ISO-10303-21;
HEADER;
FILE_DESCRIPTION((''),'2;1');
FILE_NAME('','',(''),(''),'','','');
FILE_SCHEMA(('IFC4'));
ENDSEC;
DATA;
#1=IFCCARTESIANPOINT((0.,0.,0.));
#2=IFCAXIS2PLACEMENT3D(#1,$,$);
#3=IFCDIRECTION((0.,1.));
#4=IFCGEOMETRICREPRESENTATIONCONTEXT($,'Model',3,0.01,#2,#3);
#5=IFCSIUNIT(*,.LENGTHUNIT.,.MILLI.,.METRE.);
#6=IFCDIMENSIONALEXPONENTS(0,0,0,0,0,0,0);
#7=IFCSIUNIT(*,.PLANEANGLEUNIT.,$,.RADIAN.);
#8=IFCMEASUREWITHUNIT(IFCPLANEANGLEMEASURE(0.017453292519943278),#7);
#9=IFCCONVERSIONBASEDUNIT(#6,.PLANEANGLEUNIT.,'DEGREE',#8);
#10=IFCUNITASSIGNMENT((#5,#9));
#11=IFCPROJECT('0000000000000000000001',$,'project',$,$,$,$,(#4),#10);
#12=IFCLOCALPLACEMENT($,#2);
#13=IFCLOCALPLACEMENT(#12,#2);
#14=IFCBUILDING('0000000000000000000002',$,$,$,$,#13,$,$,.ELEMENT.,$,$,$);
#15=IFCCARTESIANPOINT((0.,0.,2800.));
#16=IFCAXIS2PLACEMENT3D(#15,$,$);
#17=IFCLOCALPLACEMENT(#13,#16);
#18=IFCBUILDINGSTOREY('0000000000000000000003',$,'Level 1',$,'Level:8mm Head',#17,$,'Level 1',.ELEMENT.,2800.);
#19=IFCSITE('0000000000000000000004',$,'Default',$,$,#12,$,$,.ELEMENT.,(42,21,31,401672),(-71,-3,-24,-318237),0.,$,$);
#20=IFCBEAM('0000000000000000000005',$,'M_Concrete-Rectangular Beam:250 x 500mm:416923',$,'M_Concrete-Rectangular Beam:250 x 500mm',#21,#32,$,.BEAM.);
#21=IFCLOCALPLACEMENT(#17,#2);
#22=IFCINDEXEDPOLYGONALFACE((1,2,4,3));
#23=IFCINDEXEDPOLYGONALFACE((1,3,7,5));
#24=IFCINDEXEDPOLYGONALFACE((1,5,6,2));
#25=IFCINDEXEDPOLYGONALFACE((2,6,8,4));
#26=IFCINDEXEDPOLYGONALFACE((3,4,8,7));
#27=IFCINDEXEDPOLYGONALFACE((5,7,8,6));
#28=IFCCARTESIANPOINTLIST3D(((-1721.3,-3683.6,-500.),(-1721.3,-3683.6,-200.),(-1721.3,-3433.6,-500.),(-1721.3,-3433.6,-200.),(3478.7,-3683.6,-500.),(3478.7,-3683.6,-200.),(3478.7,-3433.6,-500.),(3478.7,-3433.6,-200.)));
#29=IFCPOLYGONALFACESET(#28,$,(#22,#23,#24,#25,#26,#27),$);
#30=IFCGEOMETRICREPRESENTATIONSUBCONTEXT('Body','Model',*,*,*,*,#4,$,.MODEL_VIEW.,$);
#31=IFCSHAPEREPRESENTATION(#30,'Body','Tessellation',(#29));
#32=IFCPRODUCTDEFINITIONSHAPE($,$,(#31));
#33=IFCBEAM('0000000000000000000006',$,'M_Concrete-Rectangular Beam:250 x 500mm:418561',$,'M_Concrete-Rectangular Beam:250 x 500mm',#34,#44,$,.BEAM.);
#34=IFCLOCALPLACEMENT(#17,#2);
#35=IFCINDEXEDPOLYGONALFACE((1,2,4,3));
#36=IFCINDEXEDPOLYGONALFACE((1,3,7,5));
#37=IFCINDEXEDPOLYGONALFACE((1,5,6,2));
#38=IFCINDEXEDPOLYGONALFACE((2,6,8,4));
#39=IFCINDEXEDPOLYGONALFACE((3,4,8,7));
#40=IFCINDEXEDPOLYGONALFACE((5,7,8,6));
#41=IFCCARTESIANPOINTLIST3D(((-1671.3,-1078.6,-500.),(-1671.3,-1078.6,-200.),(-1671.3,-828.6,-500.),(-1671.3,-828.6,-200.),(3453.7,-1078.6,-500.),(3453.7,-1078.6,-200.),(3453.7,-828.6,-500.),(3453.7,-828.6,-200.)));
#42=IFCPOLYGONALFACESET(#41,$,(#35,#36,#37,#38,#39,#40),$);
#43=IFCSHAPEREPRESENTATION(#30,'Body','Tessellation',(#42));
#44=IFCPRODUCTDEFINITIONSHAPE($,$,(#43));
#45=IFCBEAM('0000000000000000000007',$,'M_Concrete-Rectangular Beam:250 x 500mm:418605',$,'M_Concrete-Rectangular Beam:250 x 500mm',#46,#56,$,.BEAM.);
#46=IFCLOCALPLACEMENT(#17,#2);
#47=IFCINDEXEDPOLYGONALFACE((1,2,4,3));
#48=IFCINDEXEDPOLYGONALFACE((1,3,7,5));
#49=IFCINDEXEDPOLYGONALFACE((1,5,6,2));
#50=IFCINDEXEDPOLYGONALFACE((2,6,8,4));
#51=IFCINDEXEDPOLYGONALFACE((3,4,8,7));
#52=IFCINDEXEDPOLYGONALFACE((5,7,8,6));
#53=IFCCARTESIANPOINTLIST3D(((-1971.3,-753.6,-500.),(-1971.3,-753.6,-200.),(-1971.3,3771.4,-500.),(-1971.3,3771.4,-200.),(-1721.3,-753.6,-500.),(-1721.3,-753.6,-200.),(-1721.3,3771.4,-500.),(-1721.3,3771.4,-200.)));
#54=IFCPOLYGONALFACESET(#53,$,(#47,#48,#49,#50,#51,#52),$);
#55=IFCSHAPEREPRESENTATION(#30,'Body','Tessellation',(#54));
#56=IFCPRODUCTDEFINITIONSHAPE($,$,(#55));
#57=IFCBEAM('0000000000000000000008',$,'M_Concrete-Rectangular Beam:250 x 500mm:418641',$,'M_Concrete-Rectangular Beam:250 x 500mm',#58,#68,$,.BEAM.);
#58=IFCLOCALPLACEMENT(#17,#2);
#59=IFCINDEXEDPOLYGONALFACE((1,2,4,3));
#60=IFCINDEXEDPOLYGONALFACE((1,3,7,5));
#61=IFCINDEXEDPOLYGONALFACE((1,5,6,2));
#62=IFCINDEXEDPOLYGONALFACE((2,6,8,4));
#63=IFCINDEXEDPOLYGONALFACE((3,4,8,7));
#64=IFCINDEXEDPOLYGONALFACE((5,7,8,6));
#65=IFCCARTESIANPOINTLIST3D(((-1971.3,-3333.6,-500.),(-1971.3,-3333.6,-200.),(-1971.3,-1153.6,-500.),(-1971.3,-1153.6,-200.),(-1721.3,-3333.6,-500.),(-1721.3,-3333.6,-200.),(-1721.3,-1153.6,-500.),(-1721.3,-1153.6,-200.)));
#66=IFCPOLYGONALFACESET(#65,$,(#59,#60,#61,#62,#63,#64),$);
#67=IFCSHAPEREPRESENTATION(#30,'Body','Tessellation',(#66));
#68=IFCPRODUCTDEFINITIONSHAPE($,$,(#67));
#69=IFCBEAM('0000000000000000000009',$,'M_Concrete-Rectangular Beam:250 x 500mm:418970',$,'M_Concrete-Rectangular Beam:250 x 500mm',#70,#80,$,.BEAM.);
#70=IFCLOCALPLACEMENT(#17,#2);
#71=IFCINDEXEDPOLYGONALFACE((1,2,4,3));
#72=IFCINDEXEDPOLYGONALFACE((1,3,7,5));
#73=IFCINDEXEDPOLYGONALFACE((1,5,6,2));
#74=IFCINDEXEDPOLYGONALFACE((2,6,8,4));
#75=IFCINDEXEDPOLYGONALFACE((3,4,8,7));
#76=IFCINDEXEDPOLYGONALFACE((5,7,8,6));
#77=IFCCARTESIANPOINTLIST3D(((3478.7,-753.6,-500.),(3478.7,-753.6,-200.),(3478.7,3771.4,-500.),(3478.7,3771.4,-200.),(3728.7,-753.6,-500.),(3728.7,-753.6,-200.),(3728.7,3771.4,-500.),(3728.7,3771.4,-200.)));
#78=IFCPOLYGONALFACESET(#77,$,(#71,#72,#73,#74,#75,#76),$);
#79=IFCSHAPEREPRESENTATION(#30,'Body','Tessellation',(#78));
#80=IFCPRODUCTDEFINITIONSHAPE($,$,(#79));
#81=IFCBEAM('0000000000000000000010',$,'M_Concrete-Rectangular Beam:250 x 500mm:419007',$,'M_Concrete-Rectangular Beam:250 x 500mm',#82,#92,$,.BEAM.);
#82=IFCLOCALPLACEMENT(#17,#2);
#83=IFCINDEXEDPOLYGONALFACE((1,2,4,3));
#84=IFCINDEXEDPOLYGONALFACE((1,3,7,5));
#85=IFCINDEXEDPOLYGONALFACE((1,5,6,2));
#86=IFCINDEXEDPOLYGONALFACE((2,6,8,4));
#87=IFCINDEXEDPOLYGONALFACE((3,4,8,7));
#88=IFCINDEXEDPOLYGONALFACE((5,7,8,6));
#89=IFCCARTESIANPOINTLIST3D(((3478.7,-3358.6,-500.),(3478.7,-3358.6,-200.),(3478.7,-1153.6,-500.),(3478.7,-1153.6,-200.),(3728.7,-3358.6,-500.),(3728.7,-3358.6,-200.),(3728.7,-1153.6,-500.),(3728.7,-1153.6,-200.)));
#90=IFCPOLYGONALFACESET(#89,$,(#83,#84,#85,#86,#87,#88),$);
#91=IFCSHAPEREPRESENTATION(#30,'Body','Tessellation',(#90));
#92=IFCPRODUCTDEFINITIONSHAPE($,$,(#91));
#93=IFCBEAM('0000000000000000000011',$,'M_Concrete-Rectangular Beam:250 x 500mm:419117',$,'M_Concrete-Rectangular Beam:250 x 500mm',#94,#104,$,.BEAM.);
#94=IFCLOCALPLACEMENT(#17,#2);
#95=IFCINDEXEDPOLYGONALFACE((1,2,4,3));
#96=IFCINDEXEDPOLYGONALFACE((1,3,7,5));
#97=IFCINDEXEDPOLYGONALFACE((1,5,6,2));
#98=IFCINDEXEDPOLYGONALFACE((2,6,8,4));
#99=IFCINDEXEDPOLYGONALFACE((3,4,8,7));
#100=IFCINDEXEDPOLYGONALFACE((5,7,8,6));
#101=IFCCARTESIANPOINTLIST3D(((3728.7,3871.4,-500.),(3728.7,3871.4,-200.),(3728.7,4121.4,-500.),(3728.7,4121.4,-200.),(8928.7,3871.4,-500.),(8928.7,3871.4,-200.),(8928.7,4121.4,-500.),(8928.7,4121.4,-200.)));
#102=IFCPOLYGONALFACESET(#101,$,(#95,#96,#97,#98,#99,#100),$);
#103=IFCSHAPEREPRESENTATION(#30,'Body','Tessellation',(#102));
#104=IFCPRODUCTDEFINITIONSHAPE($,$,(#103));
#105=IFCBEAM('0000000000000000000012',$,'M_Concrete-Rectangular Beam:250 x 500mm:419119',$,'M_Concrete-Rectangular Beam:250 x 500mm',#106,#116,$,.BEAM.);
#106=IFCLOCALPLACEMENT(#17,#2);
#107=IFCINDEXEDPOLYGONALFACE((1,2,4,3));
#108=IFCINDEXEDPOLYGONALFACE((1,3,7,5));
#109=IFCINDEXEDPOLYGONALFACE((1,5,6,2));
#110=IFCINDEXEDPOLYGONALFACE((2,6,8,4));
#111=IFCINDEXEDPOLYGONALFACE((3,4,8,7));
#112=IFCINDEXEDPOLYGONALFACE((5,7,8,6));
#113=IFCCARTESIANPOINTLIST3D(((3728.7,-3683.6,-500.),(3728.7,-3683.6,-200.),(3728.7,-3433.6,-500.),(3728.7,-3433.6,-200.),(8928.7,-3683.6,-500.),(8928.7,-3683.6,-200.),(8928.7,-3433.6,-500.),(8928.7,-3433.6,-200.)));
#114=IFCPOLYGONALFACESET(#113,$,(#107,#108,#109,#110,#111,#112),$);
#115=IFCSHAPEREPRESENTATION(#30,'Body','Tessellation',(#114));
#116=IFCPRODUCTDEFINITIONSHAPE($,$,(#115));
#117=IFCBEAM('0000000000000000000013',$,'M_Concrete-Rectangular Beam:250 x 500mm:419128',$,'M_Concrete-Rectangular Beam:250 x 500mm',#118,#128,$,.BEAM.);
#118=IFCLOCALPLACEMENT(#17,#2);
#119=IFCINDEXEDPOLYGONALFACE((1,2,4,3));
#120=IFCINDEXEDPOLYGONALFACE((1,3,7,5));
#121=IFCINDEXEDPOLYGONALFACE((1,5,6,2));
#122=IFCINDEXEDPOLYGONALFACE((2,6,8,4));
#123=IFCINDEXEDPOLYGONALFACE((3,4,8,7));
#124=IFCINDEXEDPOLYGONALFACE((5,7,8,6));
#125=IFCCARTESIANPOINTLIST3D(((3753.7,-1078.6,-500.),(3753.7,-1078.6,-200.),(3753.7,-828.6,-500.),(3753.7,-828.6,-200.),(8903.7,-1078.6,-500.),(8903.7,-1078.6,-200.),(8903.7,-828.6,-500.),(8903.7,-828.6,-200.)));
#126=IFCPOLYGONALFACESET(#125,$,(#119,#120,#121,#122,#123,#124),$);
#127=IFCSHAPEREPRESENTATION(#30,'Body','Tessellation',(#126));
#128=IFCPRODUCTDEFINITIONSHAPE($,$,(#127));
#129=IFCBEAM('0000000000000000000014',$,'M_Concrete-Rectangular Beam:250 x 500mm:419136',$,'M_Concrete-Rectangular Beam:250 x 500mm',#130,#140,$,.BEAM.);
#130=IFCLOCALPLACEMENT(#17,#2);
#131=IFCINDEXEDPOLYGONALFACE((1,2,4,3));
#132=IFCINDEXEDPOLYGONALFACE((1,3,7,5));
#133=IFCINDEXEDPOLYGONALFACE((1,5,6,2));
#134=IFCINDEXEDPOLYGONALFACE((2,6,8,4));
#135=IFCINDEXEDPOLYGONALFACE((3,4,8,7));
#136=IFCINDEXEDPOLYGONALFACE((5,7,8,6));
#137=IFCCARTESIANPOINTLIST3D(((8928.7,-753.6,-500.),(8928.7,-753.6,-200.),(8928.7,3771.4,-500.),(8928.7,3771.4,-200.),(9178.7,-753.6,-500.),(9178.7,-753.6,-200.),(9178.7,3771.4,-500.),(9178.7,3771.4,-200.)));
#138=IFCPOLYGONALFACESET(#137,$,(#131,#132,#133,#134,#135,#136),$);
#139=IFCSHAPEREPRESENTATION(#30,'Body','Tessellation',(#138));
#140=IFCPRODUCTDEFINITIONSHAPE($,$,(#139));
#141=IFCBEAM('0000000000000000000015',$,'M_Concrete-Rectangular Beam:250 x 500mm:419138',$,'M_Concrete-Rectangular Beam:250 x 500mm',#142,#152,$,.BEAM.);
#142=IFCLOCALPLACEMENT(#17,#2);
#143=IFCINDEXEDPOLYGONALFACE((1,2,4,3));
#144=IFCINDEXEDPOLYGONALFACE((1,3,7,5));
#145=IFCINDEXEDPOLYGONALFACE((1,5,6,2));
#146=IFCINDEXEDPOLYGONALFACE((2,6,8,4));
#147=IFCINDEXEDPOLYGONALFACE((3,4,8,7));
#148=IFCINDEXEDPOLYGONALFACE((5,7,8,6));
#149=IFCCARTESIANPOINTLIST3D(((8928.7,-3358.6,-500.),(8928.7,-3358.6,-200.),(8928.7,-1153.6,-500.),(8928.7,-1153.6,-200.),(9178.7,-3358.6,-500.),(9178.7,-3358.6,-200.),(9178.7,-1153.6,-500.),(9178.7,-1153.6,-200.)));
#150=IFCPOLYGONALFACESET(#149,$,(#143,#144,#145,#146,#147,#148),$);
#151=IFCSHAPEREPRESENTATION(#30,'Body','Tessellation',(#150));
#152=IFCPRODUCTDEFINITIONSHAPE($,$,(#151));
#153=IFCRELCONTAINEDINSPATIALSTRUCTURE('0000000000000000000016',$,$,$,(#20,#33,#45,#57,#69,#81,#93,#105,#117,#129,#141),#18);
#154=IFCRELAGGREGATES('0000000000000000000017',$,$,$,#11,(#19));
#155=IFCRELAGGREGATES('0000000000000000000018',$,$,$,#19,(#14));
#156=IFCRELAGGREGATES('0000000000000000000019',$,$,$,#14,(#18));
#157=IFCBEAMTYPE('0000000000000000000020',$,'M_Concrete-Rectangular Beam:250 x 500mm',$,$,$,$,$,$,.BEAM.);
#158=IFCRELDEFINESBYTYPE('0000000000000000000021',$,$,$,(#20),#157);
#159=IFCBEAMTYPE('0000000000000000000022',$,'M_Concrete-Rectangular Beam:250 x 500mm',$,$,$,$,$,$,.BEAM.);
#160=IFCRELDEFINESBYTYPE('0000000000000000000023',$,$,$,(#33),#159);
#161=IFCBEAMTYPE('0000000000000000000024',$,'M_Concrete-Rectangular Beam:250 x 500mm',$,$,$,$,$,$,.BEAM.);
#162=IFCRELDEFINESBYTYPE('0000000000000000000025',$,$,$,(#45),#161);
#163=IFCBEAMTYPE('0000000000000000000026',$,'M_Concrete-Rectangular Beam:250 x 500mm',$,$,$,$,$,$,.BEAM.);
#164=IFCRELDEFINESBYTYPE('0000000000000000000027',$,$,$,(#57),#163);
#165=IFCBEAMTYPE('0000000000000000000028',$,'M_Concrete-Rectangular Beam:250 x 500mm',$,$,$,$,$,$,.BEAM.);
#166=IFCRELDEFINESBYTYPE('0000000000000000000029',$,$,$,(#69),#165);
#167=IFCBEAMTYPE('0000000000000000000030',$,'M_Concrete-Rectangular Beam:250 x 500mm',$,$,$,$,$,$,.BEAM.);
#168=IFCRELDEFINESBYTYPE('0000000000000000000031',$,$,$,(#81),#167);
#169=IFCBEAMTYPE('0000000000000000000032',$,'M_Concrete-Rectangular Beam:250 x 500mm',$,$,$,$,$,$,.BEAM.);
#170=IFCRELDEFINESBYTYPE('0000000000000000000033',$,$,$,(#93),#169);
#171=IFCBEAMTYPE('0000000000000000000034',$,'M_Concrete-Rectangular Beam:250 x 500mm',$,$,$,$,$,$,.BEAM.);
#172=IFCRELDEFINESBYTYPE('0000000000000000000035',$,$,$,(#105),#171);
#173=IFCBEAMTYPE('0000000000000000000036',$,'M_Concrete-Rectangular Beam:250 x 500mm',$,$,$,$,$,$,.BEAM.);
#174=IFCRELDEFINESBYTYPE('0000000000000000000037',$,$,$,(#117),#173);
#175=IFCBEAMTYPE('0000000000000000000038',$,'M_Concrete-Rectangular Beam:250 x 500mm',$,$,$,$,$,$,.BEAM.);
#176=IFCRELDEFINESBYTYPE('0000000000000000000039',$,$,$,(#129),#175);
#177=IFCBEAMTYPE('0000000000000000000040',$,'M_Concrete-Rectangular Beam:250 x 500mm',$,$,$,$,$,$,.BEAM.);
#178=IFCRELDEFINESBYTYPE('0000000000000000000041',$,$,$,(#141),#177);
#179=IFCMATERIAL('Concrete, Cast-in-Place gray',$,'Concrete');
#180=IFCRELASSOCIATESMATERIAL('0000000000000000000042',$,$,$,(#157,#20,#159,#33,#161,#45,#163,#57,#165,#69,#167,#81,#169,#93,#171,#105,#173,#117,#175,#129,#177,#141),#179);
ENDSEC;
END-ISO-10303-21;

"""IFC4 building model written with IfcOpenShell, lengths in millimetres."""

from ifc_helpers import new_model, entity, si_unit, converted_unit, direction, frame, origin, place, context, subcontext, project, spatial, indexed_curve, outline, extrude, source, transform, mapped, material, type_object, type_shapes, element, save


model = new_model("IFC4")

# Units and contexts
model_context = context("Model", 3, precision=0.01, world=origin(), true_north=direction((0.0, 1.0)))
body_context = subcontext(model_context, "Body", "Model", "MODEL_VIEW")
ifc_project = project(units=[si_unit("LENGTHUNIT", "METRE", prefix="MILLI"), converted_unit("PLANEANGLEUNIT", "DEGREE", entity("IfcPlaneAngleMeasure", 0.017453292519943278), si_unit("PLANEANGLEUNIT", "RADIAN"), dimensions=[0, 0, 0, 0, 0, 0, 0])], contexts=[model_context])

# Site, building, storey
site_placement = place(None, origin())
site = spatial("IfcSite", under=ifc_project, at=site_placement, Name="Default", CompositionType="ELEMENT", RefLatitude=(42, 21, 31, 401672), RefLongitude=(-71, -3, -24, -318237), RefElevation=0.0)
building_placement = place(site_placement, origin())
building = spatial("IfcBuilding", under=site, at=building_placement, CompositionType="ELEMENT")
storey_placement = place(building_placement, frame((0.0, 0.0, 2800.0)))
storey = spatial("IfcBuildingStorey", under=building, at=storey_placement, Name="Level 1", ObjectType="Level:8mm Head", LongName="Level 1", CompositionType="ELEMENT", Elevation=2800.0)

# Shared definitions
ifc_material_1 = material(Name="Concrete, Cast-in-Place gray", Category="Concrete")

# Beams
beam_type_1 = type_object("IfcBeamType", Name="M_Concrete-Rectangular Beam:250 x 500mm", PredefinedType="BEAM", material=ifc_material_1)
shared_shape_1 = source(origin(), body_context, "Body", "SweptSolid", [
    extrude(outline(indexed_curve([(-150.0, -125.0), (150.0, -125.0), (150.0, 125.0), (-150.0, 125.0), (-150.0, -125.0)], self_intersect=False)), frame((-1721.3, -3558.6, 2450.0), z_axis=(1.0, 0.0, 0.0), x_axis=(0.0, 0.0, -1.0)), (0.0, 0.0, 1.0), 5200.0),
])
type_shapes(beam_type_1, [shared_shape_1])
beam_1_placement = place(storey_placement, frame((0.0, 0.0, -2800.0)))
element("IfcBeam", 1, at=beam_1_placement, inside=storey, type_object=beam_type_1, material=ifc_material_1, Name="M_Concrete-Rectangular Beam:250 x 500mm:416923", ObjectType="M_Concrete-Rectangular Beam:250 x 500mm", PredefinedType="BEAM", context=body_context, shape_type="MappedRepresentation", body=[
    mapped(shared_shape_1, transform((0.0, 0.0, 0.0), scale=1.0)),
])
beam_type_2 = type_object("IfcBeamType", Name="M_Concrete-Rectangular Beam:250 x 500mm", PredefinedType="BEAM", material=ifc_material_1)
shared_shape_2 = source(origin(), body_context, "Body", "SweptSolid", [
    extrude(outline(indexed_curve([(-150.0, -125.0), (150.0, -125.0), (150.0, 125.0), (-150.0, 125.0), (-150.0, -125.0)], self_intersect=False)), frame((-1671.3, -953.6, 2450.0), z_axis=(1.0, 0.0, 0.0), x_axis=(0.0, 0.0, -1.0)), (0.0, 0.0, 1.0), 5125.0),
])
type_shapes(beam_type_2, [shared_shape_2])
beam_2_placement = place(storey_placement, frame((0.0, 0.0, -2800.0)))
element("IfcBeam", 2, at=beam_2_placement, inside=storey, type_object=beam_type_2, material=ifc_material_1, Name="M_Concrete-Rectangular Beam:250 x 500mm:418561", ObjectType="M_Concrete-Rectangular Beam:250 x 500mm", PredefinedType="BEAM", context=body_context, shape_type="MappedRepresentation", body=[
    mapped(shared_shape_2, transform((0.0, 0.0, 0.0), scale=1.0)),
])
beam_type_3 = type_object("IfcBeamType", Name="M_Concrete-Rectangular Beam:250 x 500mm", PredefinedType="BEAM", material=ifc_material_1)
shared_shape_3 = source(origin(), body_context, "Body", "SweptSolid", [
    extrude(outline(indexed_curve([(-125.0, -150.0), (125.0, -150.0), (125.0, 150.0), (-125.0, 150.0), (-125.0, -150.0)], self_intersect=False)), frame((-1846.3, 3771.4, 2450.0), z_axis=(0.0, -1.0, 0.0), x_axis=(-1.0, 0.0, 0.0)), (0.0, 0.0, 1.0), 4525.0),
])
type_shapes(beam_type_3, [shared_shape_3])
beam_3_placement = place(storey_placement, frame((0.0, 0.0, -2800.0)))
element("IfcBeam", 3, at=beam_3_placement, inside=storey, type_object=beam_type_3, material=ifc_material_1, Name="M_Concrete-Rectangular Beam:250 x 500mm:418605", ObjectType="M_Concrete-Rectangular Beam:250 x 500mm", PredefinedType="BEAM", context=body_context, shape_type="MappedRepresentation", body=[
    mapped(shared_shape_3, transform((0.0, 0.0, 0.0), scale=1.0)),
])
beam_type_4 = type_object("IfcBeamType", Name="M_Concrete-Rectangular Beam:250 x 500mm", PredefinedType="BEAM", material=ifc_material_1)
shared_shape_4 = source(origin(), body_context, "Body", "SweptSolid", [
    extrude(outline(indexed_curve([(-125.0, -150.0), (125.0, -150.0), (125.0, 150.0), (-125.0, 150.0), (-125.0, -150.0)], self_intersect=False)), frame((-1846.3, -1153.6, 2450.0), z_axis=(0.0, -1.0, 0.0), x_axis=(-1.0, 0.0, 0.0)), (0.0, 0.0, 1.0), 2180.0),
])
type_shapes(beam_type_4, [shared_shape_4])
beam_4_placement = place(storey_placement, frame((0.0, 0.0, -2800.0)))
element("IfcBeam", 4, at=beam_4_placement, inside=storey, type_object=beam_type_4, material=ifc_material_1, Name="M_Concrete-Rectangular Beam:250 x 500mm:418641", ObjectType="M_Concrete-Rectangular Beam:250 x 500mm", PredefinedType="BEAM", context=body_context, shape_type="MappedRepresentation", body=[
    mapped(shared_shape_4, transform((0.0, 0.0, 0.0), scale=1.0)),
])
beam_type_5 = type_object("IfcBeamType", Name="M_Concrete-Rectangular Beam:250 x 500mm", PredefinedType="BEAM", material=ifc_material_1)
shared_shape_5 = source(origin(), body_context, "Body", "SweptSolid", [
    extrude(outline(indexed_curve([(-125.0, -150.0), (125.0, -150.0), (125.0, 150.0), (-125.0, 150.0), (-125.0, -150.0)], self_intersect=False)), frame((3603.7, 3771.4, 2450.0), z_axis=(0.0, -1.0, 0.0), x_axis=(-1.0, 0.0, 0.0)), (0.0, 0.0, 1.0), 4525.0),
])
type_shapes(beam_type_5, [shared_shape_5])
beam_5_placement = place(storey_placement, frame((0.0, 0.0, -2800.0)))
element("IfcBeam", 5, at=beam_5_placement, inside=storey, type_object=beam_type_5, material=ifc_material_1, Name="M_Concrete-Rectangular Beam:250 x 500mm:418970", ObjectType="M_Concrete-Rectangular Beam:250 x 500mm", PredefinedType="BEAM", context=body_context, shape_type="MappedRepresentation", body=[
    mapped(shared_shape_5, transform((0.0, 0.0, 0.0), scale=1.0)),
])
beam_type_6 = type_object("IfcBeamType", Name="M_Concrete-Rectangular Beam:250 x 500mm", PredefinedType="BEAM", material=ifc_material_1)
shared_shape_6 = source(origin(), body_context, "Body", "SweptSolid", [
    extrude(outline(indexed_curve([(-125.0, -150.0), (125.0, -150.0), (125.0, 150.0), (-125.0, 150.0), (-125.0, -150.0)], self_intersect=False)), frame((3603.7, -1153.6, 2450.0), z_axis=(0.0, -1.0, 0.0), x_axis=(-1.0, 0.0, 0.0)), (0.0, 0.0, 1.0), 2205.0),
])
type_shapes(beam_type_6, [shared_shape_6])
beam_6_placement = place(storey_placement, frame((0.0, 0.0, -2800.0)))
element("IfcBeam", 6, at=beam_6_placement, inside=storey, type_object=beam_type_6, material=ifc_material_1, Name="M_Concrete-Rectangular Beam:250 x 500mm:419007", ObjectType="M_Concrete-Rectangular Beam:250 x 500mm", PredefinedType="BEAM", context=body_context, shape_type="MappedRepresentation", body=[
    mapped(shared_shape_6, transform((0.0, 0.0, 0.0), scale=1.0)),
])
beam_type_7 = type_object("IfcBeamType", Name="M_Concrete-Rectangular Beam:250 x 500mm", PredefinedType="BEAM", material=ifc_material_1)
shared_shape_7 = source(origin(), body_context, "Body", "SweptSolid", [
    extrude(outline(indexed_curve([(-150.0, -125.0), (150.0, -125.0), (150.0, 125.0), (-150.0, 125.0), (-150.0, -125.0)], self_intersect=False)), frame((3728.7, 3996.4, 2450.0), z_axis=(1.0, 0.0, 0.0), x_axis=(0.0, 0.0, -1.0)), (0.0, 0.0, 1.0), 5200.0),
])
type_shapes(beam_type_7, [shared_shape_7])
beam_7_placement = place(storey_placement, frame((0.0, 0.0, -2800.0)))
element("IfcBeam", 7, at=beam_7_placement, inside=storey, type_object=beam_type_7, material=ifc_material_1, Name="M_Concrete-Rectangular Beam:250 x 500mm:419117", ObjectType="M_Concrete-Rectangular Beam:250 x 500mm", PredefinedType="BEAM", context=body_context, shape_type="MappedRepresentation", body=[
    mapped(shared_shape_7, transform((0.0, 0.0, 0.0), scale=1.0)),
])
beam_type_8 = type_object("IfcBeamType", Name="M_Concrete-Rectangular Beam:250 x 500mm", PredefinedType="BEAM", material=ifc_material_1)
shared_shape_8 = source(origin(), body_context, "Body", "SweptSolid", [
    extrude(outline(indexed_curve([(-150.0, -125.0), (150.0, -125.0), (150.0, 125.0), (-150.0, 125.0), (-150.0, -125.0)], self_intersect=False)), frame((3728.7, -3558.6, 2450.0), z_axis=(1.0, 0.0, 0.0), x_axis=(0.0, 0.0, -1.0)), (0.0, 0.0, 1.0), 5200.0),
])
type_shapes(beam_type_8, [shared_shape_8])
beam_8_placement = place(storey_placement, frame((0.0, 0.0, -2800.0)))
element("IfcBeam", 8, at=beam_8_placement, inside=storey, type_object=beam_type_8, material=ifc_material_1, Name="M_Concrete-Rectangular Beam:250 x 500mm:419119", ObjectType="M_Concrete-Rectangular Beam:250 x 500mm", PredefinedType="BEAM", context=body_context, shape_type="MappedRepresentation", body=[
    mapped(shared_shape_8, transform((0.0, 0.0, 0.0), scale=1.0)),
])
beam_type_9 = type_object("IfcBeamType", Name="M_Concrete-Rectangular Beam:250 x 500mm", PredefinedType="BEAM", material=ifc_material_1)
shared_shape_9 = source(origin(), body_context, "Body", "SweptSolid", [
    extrude(outline(indexed_curve([(-150.0, -125.0), (150.0, -125.0), (150.0, 125.0), (-150.0, 125.0), (-150.0, -125.0)], self_intersect=False)), frame((3753.7, -953.6, 2450.0), z_axis=(1.0, 0.0, 0.0), x_axis=(0.0, 0.0, -1.0)), (0.0, 0.0, 1.0), 5150.0),
])
type_shapes(beam_type_9, [shared_shape_9])
beam_9_placement = place(storey_placement, frame((0.0, 0.0, -2800.0)))
element("IfcBeam", 9, at=beam_9_placement, inside=storey, type_object=beam_type_9, material=ifc_material_1, Name="M_Concrete-Rectangular Beam:250 x 500mm:419128", ObjectType="M_Concrete-Rectangular Beam:250 x 500mm", PredefinedType="BEAM", context=body_context, shape_type="MappedRepresentation", body=[
    mapped(shared_shape_9, transform((0.0, 0.0, 0.0), scale=1.0)),
])
beam_type_10 = type_object("IfcBeamType", Name="M_Concrete-Rectangular Beam:250 x 500mm", PredefinedType="BEAM", material=ifc_material_1)
shared_shape_10 = source(origin(), body_context, "Body", "SweptSolid", [
    extrude(outline(indexed_curve([(-125.0, -150.0), (125.0, -150.0), (125.0, 150.0), (-125.0, 150.0), (-125.0, -150.0)], self_intersect=False)), frame((9053.7, 3771.4, 2450.0), z_axis=(0.0, -1.0, 0.0), x_axis=(-1.0, 0.0, 0.0)), (0.0, 0.0, 1.0), 4525.0),
])
type_shapes(beam_type_10, [shared_shape_10])
beam_10_placement = place(storey_placement, frame((0.0, 0.0, -2800.0)))
element("IfcBeam", 10, at=beam_10_placement, inside=storey, type_object=beam_type_10, material=ifc_material_1, Name="M_Concrete-Rectangular Beam:250 x 500mm:419136", ObjectType="M_Concrete-Rectangular Beam:250 x 500mm", PredefinedType="BEAM", context=body_context, shape_type="MappedRepresentation", body=[
    mapped(shared_shape_10, transform((0.0, 0.0, 0.0), scale=1.0)),
])
beam_type_11 = type_object("IfcBeamType", Name="M_Concrete-Rectangular Beam:250 x 500mm", PredefinedType="BEAM", material=ifc_material_1)
shared_shape_11 = source(origin(), body_context, "Body", "SweptSolid", [
    extrude(outline(indexed_curve([(-125.0, -150.0), (125.0, -150.0), (125.0, 150.0), (-125.0, 150.0), (-125.0, -150.0)], self_intersect=False)), frame((9053.7, -1153.6, 2450.0), z_axis=(0.0, -1.0, 0.0), x_axis=(-1.0, 0.0, 0.0)), (0.0, 0.0, 1.0), 2205.0),
])
type_shapes(beam_type_11, [shared_shape_11])
beam_11_placement = place(storey_placement, frame((0.0, 0.0, -2800.0)))
element("IfcBeam", 11, at=beam_11_placement, inside=storey, type_object=beam_type_11, material=ifc_material_1, Name="M_Concrete-Rectangular Beam:250 x 500mm:419138", ObjectType="M_Concrete-Rectangular Beam:250 x 500mm", PredefinedType="BEAM", context=body_context, shape_type="MappedRepresentation", body=[
    mapped(shared_shape_11, transform((0.0, 0.0, 0.0), scale=1.0)),
])

save(model, "model.ifc")
